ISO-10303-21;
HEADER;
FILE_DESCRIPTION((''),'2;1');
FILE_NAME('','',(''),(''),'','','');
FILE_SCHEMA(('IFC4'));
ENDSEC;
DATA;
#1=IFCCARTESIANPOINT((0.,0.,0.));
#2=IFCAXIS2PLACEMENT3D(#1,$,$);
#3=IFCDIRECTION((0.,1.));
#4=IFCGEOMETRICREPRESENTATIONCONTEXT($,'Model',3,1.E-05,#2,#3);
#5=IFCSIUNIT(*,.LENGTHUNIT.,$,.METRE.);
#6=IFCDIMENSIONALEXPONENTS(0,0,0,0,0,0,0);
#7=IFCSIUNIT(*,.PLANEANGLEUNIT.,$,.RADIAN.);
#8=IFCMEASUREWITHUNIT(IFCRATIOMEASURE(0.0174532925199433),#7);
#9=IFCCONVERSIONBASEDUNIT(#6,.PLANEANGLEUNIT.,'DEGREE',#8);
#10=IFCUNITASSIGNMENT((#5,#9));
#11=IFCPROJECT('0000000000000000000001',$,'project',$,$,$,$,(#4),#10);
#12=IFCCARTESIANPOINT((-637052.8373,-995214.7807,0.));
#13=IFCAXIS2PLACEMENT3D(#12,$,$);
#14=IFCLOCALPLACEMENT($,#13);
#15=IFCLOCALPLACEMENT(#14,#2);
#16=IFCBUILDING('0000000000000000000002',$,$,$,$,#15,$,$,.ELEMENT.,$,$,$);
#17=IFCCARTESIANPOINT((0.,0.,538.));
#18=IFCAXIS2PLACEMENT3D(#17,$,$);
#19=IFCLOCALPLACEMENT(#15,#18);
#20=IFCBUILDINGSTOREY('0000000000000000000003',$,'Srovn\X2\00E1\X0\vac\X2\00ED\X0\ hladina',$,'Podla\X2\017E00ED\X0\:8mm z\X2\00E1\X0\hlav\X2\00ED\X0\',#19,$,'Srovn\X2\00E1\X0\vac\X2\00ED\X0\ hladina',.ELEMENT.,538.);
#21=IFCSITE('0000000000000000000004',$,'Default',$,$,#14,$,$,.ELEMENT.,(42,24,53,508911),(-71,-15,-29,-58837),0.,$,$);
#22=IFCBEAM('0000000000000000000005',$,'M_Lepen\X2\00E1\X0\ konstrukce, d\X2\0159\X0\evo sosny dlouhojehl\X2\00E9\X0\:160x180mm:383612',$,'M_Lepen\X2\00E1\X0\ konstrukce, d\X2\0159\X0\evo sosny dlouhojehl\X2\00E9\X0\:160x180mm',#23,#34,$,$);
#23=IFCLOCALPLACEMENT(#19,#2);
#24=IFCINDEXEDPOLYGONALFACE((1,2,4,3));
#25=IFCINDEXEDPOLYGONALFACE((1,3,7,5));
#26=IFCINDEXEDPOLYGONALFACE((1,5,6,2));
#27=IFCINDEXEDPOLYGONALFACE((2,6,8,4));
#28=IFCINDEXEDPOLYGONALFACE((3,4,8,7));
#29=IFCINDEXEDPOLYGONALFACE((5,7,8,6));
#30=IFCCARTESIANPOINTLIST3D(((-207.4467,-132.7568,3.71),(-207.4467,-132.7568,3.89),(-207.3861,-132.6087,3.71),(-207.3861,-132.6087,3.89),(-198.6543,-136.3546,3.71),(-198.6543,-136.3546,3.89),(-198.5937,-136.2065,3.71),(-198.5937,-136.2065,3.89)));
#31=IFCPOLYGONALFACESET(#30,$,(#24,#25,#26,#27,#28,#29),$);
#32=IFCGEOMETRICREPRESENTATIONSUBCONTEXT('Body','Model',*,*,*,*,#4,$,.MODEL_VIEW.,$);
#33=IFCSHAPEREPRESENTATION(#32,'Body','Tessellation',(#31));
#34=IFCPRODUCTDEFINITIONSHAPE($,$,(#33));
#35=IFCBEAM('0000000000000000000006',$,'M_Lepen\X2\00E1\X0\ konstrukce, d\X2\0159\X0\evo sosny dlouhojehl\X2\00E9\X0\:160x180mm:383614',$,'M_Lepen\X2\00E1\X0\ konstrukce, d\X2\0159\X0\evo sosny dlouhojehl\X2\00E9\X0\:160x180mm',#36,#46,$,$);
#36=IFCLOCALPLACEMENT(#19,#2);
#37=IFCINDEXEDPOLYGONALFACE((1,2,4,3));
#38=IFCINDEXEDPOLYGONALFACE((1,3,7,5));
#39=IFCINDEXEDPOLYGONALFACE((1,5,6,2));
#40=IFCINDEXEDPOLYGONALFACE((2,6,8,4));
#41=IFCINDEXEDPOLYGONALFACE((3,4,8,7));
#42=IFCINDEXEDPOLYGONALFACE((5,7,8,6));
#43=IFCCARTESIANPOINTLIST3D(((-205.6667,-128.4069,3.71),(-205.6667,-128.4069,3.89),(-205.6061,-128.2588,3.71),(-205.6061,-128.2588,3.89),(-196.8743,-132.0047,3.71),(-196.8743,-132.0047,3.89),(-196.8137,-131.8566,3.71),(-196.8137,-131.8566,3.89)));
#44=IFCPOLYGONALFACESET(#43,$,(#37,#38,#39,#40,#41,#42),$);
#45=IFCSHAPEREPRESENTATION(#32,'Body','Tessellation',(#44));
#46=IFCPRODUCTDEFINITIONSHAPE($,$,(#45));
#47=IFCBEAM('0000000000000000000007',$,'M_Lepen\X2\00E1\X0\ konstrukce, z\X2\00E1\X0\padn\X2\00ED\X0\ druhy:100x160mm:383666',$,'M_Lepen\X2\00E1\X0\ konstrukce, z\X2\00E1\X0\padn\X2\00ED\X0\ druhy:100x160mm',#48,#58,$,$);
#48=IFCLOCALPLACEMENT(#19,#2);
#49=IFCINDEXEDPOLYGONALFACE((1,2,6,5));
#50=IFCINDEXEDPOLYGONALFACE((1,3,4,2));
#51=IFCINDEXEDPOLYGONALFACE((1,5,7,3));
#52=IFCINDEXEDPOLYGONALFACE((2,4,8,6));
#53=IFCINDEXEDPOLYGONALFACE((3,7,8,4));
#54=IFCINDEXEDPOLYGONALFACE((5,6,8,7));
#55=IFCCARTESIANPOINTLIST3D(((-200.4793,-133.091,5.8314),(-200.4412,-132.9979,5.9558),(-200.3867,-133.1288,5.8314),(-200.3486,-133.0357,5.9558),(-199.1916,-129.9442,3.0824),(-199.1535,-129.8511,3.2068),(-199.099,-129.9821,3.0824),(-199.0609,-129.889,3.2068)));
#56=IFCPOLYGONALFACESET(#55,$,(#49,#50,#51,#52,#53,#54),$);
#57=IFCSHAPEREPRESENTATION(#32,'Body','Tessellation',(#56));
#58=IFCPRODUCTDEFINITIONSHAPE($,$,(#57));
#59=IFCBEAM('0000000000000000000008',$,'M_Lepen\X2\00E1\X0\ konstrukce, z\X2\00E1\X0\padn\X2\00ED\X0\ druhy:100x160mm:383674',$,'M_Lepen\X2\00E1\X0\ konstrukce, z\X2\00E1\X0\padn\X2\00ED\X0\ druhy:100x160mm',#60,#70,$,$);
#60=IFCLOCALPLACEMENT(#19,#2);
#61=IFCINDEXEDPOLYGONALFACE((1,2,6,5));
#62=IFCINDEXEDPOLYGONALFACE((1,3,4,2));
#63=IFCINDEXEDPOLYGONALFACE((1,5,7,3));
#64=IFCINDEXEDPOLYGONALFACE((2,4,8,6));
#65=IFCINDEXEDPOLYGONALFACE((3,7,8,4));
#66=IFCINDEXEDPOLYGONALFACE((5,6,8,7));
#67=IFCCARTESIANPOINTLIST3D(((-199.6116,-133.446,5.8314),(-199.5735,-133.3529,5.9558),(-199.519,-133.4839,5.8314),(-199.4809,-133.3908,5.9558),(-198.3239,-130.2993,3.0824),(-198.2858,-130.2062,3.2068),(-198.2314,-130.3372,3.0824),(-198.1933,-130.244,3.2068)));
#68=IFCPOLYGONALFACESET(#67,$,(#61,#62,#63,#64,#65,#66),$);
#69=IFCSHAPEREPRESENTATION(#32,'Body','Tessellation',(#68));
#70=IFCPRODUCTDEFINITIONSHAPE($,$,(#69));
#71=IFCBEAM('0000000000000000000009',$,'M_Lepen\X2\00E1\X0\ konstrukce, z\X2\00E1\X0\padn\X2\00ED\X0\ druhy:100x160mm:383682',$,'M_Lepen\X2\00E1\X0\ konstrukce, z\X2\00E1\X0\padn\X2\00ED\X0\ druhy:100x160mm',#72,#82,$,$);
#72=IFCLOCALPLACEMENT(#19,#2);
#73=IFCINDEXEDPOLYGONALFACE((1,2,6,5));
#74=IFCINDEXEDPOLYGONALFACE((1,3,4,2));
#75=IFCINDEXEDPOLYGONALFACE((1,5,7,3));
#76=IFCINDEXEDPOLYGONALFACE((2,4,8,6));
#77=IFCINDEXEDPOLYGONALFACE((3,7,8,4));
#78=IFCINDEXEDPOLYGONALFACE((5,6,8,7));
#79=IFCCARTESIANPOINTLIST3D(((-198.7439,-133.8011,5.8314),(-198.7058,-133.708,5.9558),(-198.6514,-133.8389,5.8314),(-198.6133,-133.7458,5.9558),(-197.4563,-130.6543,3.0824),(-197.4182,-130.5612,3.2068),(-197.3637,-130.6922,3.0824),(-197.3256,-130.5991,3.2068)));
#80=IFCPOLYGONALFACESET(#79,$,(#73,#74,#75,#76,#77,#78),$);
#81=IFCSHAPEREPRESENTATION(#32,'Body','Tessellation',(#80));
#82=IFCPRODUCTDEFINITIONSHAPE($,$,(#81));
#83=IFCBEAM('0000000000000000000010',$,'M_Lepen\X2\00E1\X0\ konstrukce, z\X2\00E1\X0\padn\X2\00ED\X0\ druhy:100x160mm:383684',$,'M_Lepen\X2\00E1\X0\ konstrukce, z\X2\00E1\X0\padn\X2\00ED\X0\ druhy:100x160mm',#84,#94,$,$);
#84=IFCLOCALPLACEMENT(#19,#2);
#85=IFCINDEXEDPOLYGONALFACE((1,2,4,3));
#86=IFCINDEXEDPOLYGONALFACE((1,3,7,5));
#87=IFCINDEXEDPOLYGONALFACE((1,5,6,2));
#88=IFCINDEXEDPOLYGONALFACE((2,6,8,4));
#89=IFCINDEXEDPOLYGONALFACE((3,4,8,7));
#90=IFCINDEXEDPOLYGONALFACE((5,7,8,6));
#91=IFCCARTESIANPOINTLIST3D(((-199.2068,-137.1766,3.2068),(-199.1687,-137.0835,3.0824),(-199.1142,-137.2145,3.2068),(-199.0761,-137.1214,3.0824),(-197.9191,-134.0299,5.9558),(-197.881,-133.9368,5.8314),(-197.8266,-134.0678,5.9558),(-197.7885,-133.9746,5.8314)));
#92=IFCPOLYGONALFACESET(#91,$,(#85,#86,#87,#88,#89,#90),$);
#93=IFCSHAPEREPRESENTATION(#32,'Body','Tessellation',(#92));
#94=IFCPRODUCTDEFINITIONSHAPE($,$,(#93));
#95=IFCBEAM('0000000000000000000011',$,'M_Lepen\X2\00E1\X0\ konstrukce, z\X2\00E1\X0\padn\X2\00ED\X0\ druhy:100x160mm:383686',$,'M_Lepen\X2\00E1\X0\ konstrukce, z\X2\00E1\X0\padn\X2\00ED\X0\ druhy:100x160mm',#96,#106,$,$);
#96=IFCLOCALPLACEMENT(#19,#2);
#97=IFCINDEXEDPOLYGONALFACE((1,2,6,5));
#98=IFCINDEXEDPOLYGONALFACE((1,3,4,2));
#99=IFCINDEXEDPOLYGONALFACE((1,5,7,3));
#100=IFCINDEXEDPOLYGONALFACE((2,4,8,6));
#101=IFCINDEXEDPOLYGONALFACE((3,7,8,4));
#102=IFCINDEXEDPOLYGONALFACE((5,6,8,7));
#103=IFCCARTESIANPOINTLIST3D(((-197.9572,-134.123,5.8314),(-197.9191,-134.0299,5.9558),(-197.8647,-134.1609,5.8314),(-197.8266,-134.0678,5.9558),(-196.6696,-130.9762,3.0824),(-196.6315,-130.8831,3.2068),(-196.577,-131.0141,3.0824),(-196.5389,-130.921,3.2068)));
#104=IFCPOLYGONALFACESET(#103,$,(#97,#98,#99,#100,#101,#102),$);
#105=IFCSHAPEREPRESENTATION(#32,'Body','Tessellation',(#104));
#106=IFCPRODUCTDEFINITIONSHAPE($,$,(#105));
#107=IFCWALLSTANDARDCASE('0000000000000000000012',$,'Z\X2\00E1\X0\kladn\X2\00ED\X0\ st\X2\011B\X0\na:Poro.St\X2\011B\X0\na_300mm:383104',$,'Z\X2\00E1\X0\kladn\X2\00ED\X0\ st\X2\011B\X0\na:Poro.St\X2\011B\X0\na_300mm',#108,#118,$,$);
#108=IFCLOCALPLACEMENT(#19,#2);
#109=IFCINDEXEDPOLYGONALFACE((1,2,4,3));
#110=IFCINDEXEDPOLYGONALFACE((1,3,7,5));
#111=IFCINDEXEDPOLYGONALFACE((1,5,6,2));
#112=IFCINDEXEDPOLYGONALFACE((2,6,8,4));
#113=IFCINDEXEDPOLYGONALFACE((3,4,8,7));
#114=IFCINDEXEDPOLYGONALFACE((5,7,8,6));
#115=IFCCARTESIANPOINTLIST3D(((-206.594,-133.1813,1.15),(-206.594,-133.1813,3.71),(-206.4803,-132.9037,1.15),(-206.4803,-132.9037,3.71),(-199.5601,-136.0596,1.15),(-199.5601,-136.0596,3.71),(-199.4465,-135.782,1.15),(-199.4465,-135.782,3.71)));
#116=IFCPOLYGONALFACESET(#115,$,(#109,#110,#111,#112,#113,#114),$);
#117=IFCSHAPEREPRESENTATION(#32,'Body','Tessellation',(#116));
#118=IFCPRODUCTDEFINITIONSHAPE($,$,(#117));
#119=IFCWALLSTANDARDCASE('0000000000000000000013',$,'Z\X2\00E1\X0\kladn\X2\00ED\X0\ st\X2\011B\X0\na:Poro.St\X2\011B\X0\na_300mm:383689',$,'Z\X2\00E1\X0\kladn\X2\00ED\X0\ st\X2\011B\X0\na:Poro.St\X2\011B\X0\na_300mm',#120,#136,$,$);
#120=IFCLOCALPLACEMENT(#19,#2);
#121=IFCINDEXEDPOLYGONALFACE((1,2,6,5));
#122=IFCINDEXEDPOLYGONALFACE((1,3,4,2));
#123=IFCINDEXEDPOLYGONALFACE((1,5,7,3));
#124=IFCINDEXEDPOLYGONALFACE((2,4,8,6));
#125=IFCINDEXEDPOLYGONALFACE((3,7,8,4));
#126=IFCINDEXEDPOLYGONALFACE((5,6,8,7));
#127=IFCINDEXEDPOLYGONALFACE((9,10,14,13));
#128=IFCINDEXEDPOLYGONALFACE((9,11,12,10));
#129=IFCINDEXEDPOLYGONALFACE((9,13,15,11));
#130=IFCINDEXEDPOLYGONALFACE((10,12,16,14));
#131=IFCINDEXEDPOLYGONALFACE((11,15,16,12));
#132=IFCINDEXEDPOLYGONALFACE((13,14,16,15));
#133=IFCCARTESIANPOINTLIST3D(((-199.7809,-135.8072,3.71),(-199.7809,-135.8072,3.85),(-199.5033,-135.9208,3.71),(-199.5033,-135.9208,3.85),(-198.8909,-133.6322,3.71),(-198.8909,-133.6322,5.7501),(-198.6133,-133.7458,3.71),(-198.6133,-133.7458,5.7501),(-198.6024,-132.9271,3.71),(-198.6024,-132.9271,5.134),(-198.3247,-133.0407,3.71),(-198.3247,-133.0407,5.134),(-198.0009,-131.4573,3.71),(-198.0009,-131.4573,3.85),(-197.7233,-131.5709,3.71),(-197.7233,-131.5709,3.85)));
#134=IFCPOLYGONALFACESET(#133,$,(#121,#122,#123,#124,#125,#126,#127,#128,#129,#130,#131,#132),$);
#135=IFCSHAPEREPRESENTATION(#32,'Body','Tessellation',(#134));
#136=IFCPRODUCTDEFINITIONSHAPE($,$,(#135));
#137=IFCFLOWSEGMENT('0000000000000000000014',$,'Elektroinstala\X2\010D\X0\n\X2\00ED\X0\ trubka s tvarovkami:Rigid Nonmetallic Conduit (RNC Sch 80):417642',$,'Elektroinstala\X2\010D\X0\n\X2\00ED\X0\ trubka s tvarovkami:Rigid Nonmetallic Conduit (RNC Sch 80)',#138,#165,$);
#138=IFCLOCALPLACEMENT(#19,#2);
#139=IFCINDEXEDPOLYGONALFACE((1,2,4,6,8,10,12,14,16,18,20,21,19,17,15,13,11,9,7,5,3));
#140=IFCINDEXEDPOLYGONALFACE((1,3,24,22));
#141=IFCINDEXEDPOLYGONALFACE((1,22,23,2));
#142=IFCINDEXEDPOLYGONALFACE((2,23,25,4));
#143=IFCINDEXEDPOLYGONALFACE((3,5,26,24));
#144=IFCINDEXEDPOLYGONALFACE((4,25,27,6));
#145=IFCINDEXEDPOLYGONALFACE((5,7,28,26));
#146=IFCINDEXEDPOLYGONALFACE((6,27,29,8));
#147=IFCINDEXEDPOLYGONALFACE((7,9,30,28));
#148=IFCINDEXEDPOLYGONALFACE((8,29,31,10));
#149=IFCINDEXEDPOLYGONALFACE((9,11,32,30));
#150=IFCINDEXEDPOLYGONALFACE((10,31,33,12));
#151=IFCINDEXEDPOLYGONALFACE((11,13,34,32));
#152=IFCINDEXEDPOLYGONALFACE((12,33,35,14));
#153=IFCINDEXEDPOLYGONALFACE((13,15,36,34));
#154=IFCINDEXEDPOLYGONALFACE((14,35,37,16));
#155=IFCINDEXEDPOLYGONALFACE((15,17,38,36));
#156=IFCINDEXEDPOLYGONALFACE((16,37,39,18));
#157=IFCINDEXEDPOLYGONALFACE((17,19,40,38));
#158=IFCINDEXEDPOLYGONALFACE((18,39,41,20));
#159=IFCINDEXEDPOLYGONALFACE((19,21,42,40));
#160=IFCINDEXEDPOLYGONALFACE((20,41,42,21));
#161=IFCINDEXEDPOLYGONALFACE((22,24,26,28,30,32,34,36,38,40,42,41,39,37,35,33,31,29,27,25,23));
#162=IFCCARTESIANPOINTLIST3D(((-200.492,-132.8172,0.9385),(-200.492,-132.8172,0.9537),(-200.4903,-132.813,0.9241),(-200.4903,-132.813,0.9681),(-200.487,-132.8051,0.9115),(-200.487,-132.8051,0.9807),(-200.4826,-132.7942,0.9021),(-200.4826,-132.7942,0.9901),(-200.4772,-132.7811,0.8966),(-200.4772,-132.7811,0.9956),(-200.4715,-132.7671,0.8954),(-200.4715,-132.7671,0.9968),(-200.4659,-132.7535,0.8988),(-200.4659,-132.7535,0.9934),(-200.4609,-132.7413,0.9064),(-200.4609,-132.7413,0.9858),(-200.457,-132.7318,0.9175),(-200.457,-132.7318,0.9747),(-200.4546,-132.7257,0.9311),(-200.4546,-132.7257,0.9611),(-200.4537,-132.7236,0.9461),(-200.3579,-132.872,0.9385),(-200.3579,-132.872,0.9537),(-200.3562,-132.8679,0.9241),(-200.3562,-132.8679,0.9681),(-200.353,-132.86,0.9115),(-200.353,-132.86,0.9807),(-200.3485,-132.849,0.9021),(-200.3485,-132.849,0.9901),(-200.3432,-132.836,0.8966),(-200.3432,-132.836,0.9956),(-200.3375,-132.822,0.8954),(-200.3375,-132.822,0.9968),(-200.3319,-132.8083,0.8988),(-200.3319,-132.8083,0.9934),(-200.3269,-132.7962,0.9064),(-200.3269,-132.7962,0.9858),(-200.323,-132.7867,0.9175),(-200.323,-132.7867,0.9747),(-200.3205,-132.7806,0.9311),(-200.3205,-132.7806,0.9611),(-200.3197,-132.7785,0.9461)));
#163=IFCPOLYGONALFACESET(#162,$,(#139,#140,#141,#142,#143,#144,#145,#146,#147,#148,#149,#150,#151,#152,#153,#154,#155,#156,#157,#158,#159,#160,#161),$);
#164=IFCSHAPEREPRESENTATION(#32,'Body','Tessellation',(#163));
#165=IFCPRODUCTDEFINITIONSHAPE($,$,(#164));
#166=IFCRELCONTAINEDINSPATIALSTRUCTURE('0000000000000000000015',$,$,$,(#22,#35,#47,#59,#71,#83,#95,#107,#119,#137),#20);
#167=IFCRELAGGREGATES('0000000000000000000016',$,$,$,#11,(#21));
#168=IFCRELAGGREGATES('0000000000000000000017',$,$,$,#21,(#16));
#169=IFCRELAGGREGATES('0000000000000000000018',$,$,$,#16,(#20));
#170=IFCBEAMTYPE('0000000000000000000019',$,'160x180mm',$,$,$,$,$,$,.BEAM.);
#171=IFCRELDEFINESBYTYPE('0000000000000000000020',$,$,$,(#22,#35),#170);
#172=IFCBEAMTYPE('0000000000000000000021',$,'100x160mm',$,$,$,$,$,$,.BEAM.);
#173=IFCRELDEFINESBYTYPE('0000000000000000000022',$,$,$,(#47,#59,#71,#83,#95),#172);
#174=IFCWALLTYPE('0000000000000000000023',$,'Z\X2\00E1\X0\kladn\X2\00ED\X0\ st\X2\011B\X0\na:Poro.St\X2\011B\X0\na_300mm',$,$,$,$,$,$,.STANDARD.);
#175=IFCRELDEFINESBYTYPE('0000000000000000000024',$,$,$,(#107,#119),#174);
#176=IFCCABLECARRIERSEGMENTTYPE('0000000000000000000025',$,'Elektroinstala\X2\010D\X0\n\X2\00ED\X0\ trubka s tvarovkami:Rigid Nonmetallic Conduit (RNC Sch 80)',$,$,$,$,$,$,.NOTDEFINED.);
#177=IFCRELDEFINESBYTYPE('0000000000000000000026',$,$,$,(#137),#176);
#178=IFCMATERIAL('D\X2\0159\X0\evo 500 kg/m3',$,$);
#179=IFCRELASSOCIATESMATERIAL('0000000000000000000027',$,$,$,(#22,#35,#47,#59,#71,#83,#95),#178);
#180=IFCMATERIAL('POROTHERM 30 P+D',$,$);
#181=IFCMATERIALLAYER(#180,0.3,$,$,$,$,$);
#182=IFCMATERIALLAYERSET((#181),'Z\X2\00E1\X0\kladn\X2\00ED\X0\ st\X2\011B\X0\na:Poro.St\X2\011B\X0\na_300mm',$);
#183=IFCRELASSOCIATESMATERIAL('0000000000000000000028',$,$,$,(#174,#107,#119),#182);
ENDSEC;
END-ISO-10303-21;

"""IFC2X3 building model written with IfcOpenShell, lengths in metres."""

from ifc_helpers import new_model, entity, si_unit, converted_unit, direction, frame, frame_2d, origin, origin_2d_with_axis, place, context, subcontext, project, spatial, polyline, rectangle, circle, outline, extrude, clip, halfspace, material, layer, layer_set, layer_usage, type_object, element, save


model = new_model("IFC2X3")

# Units and contexts
model_context = context("Model", 3, precision=1e-05, world=origin(), true_north=direction((0.0, 1.0)))
body_context = subcontext(model_context, "Body", "Model", "MODEL_VIEW")
ifc_project = project(units=[si_unit("LENGTHUNIT", "METRE"), converted_unit("PLANEANGLEUNIT", "DEGREE", entity("IfcRatioMeasure", 0.0174532925199433), si_unit("PLANEANGLEUNIT", "RADIAN"), dimensions=[0, 0, 0, 0, 0, 0, 0])], contexts=[model_context])

# Site, building, storey
site_placement = place(None, frame((-637052.8373, -995214.7807, 0.0)))
site = spatial("IfcSite", under=ifc_project, at=site_placement, Name="Default", CompositionType="ELEMENT", RefLatitude=(42, 24, 53, 508911), RefLongitude=(-71, -15, -29, -58837), RefElevation=0.0)
building_placement = place(site_placement, origin())
building = spatial("IfcBuilding", under=site, at=building_placement, CompositionType="ELEMENT")
storey_placement = place(building_placement, frame((0.0, 0.0, 538.0)))
storey = spatial("IfcBuildingStorey", under=building, at=storey_placement, Name="Srovnávací hladina", ObjectType="Podlaží:8mm záhlaví", LongName="Srovnávací hladina", CompositionType="ELEMENT", Elevation=538.0)

# Beams
ifc_material_1 = material(Name="Dřevo 500 kg/m3")
beam_type_1 = type_object("IfcBeamType", Name="160x180mm", PredefinedType="BEAM")
beam_1_placement = place(storey_placement, frame((-198.624, -136.2806, 3.02), z_axis=(0.0, 0.0, 1.0), x_axis=(-0.92551, 0.378722, 0.0)))
element("IfcBeam", 1, at=beam_1_placement, inside=storey, type_object=beam_type_1, material=ifc_material_1, Name="M_Lepená konstrukce, dřevo sosny dlouhojehlé:160x180mm:383612", ObjectType="M_Lepená konstrukce, dřevo sosny dlouhojehlé:160x180mm", context=body_context, shape_type="SweptSolid", body=[
    extrude(rectangle(XDim=0.18, YDim=0.16, at=frame_2d((0.0, 0.0), x_axis=(1.0, 0.0))), frame((0.0, 0.0, 0.78), z_axis=(1.0, 0.0, 0.0), x_axis=(0.0, 0.0, -1.0)), (0.0, 0.0, 1.0), 9.5),
])
beam_2_placement = place(storey_placement, frame((-196.844, -131.9307, 3.02), z_axis=(0.0, 0.0, 1.0), x_axis=(-0.92551, 0.378722, 0.0)))
element("IfcBeam", 2, at=beam_2_placement, inside=storey, type_object=beam_type_1, material=ifc_material_1, Name="M_Lepená konstrukce, dřevo sosny dlouhojehlé:160x180mm:383614", ObjectType="M_Lepená konstrukce, dřevo sosny dlouhojehlé:160x180mm", context=body_context, shape_type="SweptSolid", body=[
    extrude(rectangle(XDim=0.18, YDim=0.16, at=origin_2d_with_axis()), frame((0.0, 0.0, 0.78), z_axis=(1.0, 0.0, 0.0), x_axis=(0.0, 0.0, -1.0)), (0.0, 0.0, 1.0), 9.5),
])
beam_type_2 = type_object("IfcBeamType", Name="100x160mm", PredefinedType="BEAM")
beam_3_placement = place(storey_placement, frame((-199.1072, -129.8701, 3.2068), z_axis=(0.238114, 0.581897, 0.777623), x_axis=(-0.294503, -0.719698, 0.628731)))
element("IfcBeam", 3, at=beam_3_placement, inside=storey, type_object=beam_type_2, material=ifc_material_1, Name="M_Lepená konstrukce, západní druhy:100x160mm:383666", ObjectType="M_Lepená konstrukce, západní druhy:100x160mm", context=body_context, shape_type="SweptSolid", body=[
    extrude(rectangle(XDim=0.16, YDim=0.1, at=frame_2d((0.0, 0.0), x_axis=(1.0, 0.0))), frame((0.0, 0.0, -0.08), z_axis=(1.0, 0.0, 0.0), x_axis=(0.0, 0.0, -1.0)), (0.0, 0.0, 1.0), 4.3723),
])
beam_4_placement = place(storey_placement, frame((-198.2396, -130.2251, 3.2068), z_axis=(0.238114, 0.581897, 0.777623), x_axis=(-0.294503, -0.719698, 0.628731)))
element("IfcBeam", 4, at=beam_4_placement, inside=storey, type_object=beam_type_2, material=ifc_material_1, Name="M_Lepená konstrukce, západní druhy:100x160mm:383674", ObjectType="M_Lepená konstrukce, západní druhy:100x160mm", context=body_context, shape_type="SweptSolid", body=[
    extrude(rectangle(XDim=0.16, YDim=0.1, at=frame_2d((0.0, 0.0), x_axis=(1.0, 0.0))), frame((0.0, 0.0, -0.08), z_axis=(1.0, 0.0, 0.0), x_axis=(0.0, 0.0, -1.0)), (0.0, 0.0, 1.0), 4.3723),
])
beam_5_placement = place(storey_placement, frame((-197.3719, -130.5802, 3.2068), z_axis=(0.238114, 0.581897, 0.777623), x_axis=(-0.294503, -0.719698, 0.628731)))
element("IfcBeam", 5, at=beam_5_placement, inside=storey, type_object=beam_type_2, material=ifc_material_1, Name="M_Lepená konstrukce, západní druhy:100x160mm:383682", ObjectType="M_Lepená konstrukce, západní druhy:100x160mm", context=body_context, shape_type="SweptSolid", body=[
    extrude(rectangle(XDim=0.16, YDim=0.1, at=frame_2d((0.0, 0.0), x_axis=(1.0, 0.0))), frame((0.0, 0.0, -0.08), z_axis=(1.0, 0.0, 0.0), x_axis=(0.0, 0.0, -1.0)), (0.0, 0.0, 1.0), 4.3723),
])
beam_6_placement = place(storey_placement, frame((-199.1605, -137.1956, 3.2068), z_axis=(-0.238114, -0.581897, 0.777623), x_axis=(0.294503, 0.719698, 0.628731)))
element("IfcBeam", 6, at=beam_6_placement, inside=storey, type_object=beam_type_2, material=ifc_material_1, Name="M_Lepená konstrukce, západní druhy:100x160mm:383684", ObjectType="M_Lepená konstrukce, západní druhy:100x160mm", context=body_context, shape_type="SweptSolid", body=[
    extrude(rectangle(XDim=0.16, YDim=0.1, at=frame_2d((0.0, 0.0), x_axis=(1.0, 0.0))), frame((0.0, 0.0, -0.08), z_axis=(1.0, 0.0, 0.0), x_axis=(0.0, 0.0, -1.0)), (0.0, 0.0, 1.0), 4.3723),
])
beam_7_placement = place(storey_placement, frame((-196.5852, -130.9021, 3.2068), z_axis=(0.238114, 0.581897, 0.777623), x_axis=(-0.294503, -0.719698, 0.628731)))
element("IfcBeam", 7, at=beam_7_placement, inside=storey, type_object=beam_type_2, material=ifc_material_1, Name="M_Lepená konstrukce, západní druhy:100x160mm:383686", ObjectType="M_Lepená konstrukce, západní druhy:100x160mm", context=body_context, shape_type="SweptSolid", body=[
    extrude(rectangle(XDim=0.16, YDim=0.1, at=frame_2d((0.0, 0.0), x_axis=(1.0, 0.0))), frame((0.0, 0.0, -0.08), z_axis=(1.0, 0.0, 0.0), x_axis=(0.0, 0.0, -1.0)), (0.0, 0.0, 1.0), 4.3723),
])

# Wall, opening
ifc_material_2 = material(Name="POROTHERM 30 P+D")
ifc_layer = layer(ifc_material_2, 0.3)
ifc_layer_set = layer_set([ifc_layer], Name="Základní stěna:Poro.Stěna_300mm")
ifc_layer_usage_1 = layer_usage(ifc_layer_set, "AXIS2", "POSITIVE", -0.15)
wall_type = type_object("IfcWallType", Name="Základní stěna:Poro.Stěna_300mm", PredefinedType="STANDARD", material=ifc_layer_set)
wall_1_placement = place(storey_placement, frame((-199.5033, -135.9208, 1.15), z_axis=(0.0, 0.0, 1.0), x_axis=(-0.92551, 0.378722, 0.0)))
wall_1 = element("IfcWallStandardCase", 8, at=wall_1_placement, inside=storey, type_object=wall_type, material=ifc_layer_usage_1, Name="Základní stěna:Poro.Stěna_300mm:383104", ObjectType="Základní stěna:Poro.Stěna_300mm", context=body_context, shape_type="SweptSolid", body=[
    extrude(rectangle(XDim=7.6, YDim=0.3, at=frame_2d((3.8, 0.0), x_axis=(-1.0, 0.0))), origin(), (0.0, 0.0, 1.0), 2.56),
])
opening_1_placement = place(wall_1_placement, origin())
element("IfcOpeningElement", 9, at=opening_1_placement, cuts=wall_1, ObjectType="Opening", context=body_context, shape_type="SweptSolid", body=[
    extrude(rectangle(XDim=2.2, YDim=0.3, at=frame_2d((0.0, 0.0), x_axis=(0.0, 1.0))), frame((0.15, -2.4, -0.05), z_axis=(0.0, 1.0, 0.0), x_axis=(1.0, 0.0, 0.0)), (0.0, 0.0, 1.0), 1.7),
])

# Wall, opening
ifc_layer_usage_2 = layer_usage(ifc_layer_set, "AXIS2", "POSITIVE", -0.15)
wall_2_placement = place(storey_placement, frame((-197.8621, -131.5141, 3.71), z_axis=(0.0, 0.0, 1.0), x_axis=(-0.378722, -0.92551, 0.0)))
wall_2 = element("IfcWallStandardCase", 10, at=wall_2_placement, inside=storey, type_object=wall_type, material=ifc_layer_usage_2, Name="Základní stěna:Poro.Stěna_300mm:383689", ObjectType="Základní stěna:Poro.Stěna_300mm", context=body_context, shape_type="Clipping", body=[
    clip(clip(extrude(rectangle(XDim=4.7, YDim=0.3, at=frame_2d((2.35, 0.0), x_axis=(-1.0, 0.0))), origin(), (0.0, 0.0, 1.0), 2.0401), halfspace(frame((2.35, -0.15, 2.04), z_axis=(0.628731, 0.0, 0.777623), x_axis=(0.0, 1.0, 0.0)), False)), halfspace(frame((0.0, 0.15, 0.14), z_axis=(-0.628731, 0.0, 0.777623), x_axis=(0.0, 1.0, 0.0)), False)),
])
opening_2_placement = place(wall_2_placement, frame((1.5881, -0.15, -0.24)))
element("IfcOpeningElement", 11, at=opening_2_placement, cuts=wall_2, ObjectType="Opening", context=body_context, shape_type="SweptSolid", body=[
    extrude(outline(polyline([(0.0, 0.7619), (0.0, 0.0), (1.6649, 0.0), (2.281, 0.7619), (0.0, 0.7619)])), frame((0.0, 0.0, 0.0), z_axis=(0.0, 1.0, 0.0), x_axis=(0.0, 0.0, 1.0)), (0.0, 0.0, 1.0), 0.3),
])

# Flow segment
cable_carrier_segment_type = type_object("IfcCableCarrierSegmentType", Name="Elektroinstalační trubka s tvarovkami:Rigid Nonmetallic Conduit (RNC Sch 80)", PredefinedType="NOTDEFINED")
flow_segment_1_placement = place(storey_placement, origin())
element("IfcFlowSegment", 12, at=flow_segment_1_placement, inside=storey, type_object=cable_carrier_segment_type, Name="Elektroinstalační trubka s tvarovkami:Rigid Nonmetallic Conduit (RNC Sch 80):417642", ObjectType="Elektroinstalační trubka s tvarovkami:Rigid Nonmetallic Conduit (RNC Sch 80)", context=body_context, shape_type="SweptSolid", body=[
    extrude(circle(Radius=0.0508, at=origin_2d_with_axis()), frame((-200.4729, -132.7707, 0.9461), z_axis=(0.92551, -0.378722, 0.0), x_axis=(0.378722, 0.92551, 0.0)), (0.0, 0.0, 1.0), 0.1448),
])

save(model, "model.ifc")
